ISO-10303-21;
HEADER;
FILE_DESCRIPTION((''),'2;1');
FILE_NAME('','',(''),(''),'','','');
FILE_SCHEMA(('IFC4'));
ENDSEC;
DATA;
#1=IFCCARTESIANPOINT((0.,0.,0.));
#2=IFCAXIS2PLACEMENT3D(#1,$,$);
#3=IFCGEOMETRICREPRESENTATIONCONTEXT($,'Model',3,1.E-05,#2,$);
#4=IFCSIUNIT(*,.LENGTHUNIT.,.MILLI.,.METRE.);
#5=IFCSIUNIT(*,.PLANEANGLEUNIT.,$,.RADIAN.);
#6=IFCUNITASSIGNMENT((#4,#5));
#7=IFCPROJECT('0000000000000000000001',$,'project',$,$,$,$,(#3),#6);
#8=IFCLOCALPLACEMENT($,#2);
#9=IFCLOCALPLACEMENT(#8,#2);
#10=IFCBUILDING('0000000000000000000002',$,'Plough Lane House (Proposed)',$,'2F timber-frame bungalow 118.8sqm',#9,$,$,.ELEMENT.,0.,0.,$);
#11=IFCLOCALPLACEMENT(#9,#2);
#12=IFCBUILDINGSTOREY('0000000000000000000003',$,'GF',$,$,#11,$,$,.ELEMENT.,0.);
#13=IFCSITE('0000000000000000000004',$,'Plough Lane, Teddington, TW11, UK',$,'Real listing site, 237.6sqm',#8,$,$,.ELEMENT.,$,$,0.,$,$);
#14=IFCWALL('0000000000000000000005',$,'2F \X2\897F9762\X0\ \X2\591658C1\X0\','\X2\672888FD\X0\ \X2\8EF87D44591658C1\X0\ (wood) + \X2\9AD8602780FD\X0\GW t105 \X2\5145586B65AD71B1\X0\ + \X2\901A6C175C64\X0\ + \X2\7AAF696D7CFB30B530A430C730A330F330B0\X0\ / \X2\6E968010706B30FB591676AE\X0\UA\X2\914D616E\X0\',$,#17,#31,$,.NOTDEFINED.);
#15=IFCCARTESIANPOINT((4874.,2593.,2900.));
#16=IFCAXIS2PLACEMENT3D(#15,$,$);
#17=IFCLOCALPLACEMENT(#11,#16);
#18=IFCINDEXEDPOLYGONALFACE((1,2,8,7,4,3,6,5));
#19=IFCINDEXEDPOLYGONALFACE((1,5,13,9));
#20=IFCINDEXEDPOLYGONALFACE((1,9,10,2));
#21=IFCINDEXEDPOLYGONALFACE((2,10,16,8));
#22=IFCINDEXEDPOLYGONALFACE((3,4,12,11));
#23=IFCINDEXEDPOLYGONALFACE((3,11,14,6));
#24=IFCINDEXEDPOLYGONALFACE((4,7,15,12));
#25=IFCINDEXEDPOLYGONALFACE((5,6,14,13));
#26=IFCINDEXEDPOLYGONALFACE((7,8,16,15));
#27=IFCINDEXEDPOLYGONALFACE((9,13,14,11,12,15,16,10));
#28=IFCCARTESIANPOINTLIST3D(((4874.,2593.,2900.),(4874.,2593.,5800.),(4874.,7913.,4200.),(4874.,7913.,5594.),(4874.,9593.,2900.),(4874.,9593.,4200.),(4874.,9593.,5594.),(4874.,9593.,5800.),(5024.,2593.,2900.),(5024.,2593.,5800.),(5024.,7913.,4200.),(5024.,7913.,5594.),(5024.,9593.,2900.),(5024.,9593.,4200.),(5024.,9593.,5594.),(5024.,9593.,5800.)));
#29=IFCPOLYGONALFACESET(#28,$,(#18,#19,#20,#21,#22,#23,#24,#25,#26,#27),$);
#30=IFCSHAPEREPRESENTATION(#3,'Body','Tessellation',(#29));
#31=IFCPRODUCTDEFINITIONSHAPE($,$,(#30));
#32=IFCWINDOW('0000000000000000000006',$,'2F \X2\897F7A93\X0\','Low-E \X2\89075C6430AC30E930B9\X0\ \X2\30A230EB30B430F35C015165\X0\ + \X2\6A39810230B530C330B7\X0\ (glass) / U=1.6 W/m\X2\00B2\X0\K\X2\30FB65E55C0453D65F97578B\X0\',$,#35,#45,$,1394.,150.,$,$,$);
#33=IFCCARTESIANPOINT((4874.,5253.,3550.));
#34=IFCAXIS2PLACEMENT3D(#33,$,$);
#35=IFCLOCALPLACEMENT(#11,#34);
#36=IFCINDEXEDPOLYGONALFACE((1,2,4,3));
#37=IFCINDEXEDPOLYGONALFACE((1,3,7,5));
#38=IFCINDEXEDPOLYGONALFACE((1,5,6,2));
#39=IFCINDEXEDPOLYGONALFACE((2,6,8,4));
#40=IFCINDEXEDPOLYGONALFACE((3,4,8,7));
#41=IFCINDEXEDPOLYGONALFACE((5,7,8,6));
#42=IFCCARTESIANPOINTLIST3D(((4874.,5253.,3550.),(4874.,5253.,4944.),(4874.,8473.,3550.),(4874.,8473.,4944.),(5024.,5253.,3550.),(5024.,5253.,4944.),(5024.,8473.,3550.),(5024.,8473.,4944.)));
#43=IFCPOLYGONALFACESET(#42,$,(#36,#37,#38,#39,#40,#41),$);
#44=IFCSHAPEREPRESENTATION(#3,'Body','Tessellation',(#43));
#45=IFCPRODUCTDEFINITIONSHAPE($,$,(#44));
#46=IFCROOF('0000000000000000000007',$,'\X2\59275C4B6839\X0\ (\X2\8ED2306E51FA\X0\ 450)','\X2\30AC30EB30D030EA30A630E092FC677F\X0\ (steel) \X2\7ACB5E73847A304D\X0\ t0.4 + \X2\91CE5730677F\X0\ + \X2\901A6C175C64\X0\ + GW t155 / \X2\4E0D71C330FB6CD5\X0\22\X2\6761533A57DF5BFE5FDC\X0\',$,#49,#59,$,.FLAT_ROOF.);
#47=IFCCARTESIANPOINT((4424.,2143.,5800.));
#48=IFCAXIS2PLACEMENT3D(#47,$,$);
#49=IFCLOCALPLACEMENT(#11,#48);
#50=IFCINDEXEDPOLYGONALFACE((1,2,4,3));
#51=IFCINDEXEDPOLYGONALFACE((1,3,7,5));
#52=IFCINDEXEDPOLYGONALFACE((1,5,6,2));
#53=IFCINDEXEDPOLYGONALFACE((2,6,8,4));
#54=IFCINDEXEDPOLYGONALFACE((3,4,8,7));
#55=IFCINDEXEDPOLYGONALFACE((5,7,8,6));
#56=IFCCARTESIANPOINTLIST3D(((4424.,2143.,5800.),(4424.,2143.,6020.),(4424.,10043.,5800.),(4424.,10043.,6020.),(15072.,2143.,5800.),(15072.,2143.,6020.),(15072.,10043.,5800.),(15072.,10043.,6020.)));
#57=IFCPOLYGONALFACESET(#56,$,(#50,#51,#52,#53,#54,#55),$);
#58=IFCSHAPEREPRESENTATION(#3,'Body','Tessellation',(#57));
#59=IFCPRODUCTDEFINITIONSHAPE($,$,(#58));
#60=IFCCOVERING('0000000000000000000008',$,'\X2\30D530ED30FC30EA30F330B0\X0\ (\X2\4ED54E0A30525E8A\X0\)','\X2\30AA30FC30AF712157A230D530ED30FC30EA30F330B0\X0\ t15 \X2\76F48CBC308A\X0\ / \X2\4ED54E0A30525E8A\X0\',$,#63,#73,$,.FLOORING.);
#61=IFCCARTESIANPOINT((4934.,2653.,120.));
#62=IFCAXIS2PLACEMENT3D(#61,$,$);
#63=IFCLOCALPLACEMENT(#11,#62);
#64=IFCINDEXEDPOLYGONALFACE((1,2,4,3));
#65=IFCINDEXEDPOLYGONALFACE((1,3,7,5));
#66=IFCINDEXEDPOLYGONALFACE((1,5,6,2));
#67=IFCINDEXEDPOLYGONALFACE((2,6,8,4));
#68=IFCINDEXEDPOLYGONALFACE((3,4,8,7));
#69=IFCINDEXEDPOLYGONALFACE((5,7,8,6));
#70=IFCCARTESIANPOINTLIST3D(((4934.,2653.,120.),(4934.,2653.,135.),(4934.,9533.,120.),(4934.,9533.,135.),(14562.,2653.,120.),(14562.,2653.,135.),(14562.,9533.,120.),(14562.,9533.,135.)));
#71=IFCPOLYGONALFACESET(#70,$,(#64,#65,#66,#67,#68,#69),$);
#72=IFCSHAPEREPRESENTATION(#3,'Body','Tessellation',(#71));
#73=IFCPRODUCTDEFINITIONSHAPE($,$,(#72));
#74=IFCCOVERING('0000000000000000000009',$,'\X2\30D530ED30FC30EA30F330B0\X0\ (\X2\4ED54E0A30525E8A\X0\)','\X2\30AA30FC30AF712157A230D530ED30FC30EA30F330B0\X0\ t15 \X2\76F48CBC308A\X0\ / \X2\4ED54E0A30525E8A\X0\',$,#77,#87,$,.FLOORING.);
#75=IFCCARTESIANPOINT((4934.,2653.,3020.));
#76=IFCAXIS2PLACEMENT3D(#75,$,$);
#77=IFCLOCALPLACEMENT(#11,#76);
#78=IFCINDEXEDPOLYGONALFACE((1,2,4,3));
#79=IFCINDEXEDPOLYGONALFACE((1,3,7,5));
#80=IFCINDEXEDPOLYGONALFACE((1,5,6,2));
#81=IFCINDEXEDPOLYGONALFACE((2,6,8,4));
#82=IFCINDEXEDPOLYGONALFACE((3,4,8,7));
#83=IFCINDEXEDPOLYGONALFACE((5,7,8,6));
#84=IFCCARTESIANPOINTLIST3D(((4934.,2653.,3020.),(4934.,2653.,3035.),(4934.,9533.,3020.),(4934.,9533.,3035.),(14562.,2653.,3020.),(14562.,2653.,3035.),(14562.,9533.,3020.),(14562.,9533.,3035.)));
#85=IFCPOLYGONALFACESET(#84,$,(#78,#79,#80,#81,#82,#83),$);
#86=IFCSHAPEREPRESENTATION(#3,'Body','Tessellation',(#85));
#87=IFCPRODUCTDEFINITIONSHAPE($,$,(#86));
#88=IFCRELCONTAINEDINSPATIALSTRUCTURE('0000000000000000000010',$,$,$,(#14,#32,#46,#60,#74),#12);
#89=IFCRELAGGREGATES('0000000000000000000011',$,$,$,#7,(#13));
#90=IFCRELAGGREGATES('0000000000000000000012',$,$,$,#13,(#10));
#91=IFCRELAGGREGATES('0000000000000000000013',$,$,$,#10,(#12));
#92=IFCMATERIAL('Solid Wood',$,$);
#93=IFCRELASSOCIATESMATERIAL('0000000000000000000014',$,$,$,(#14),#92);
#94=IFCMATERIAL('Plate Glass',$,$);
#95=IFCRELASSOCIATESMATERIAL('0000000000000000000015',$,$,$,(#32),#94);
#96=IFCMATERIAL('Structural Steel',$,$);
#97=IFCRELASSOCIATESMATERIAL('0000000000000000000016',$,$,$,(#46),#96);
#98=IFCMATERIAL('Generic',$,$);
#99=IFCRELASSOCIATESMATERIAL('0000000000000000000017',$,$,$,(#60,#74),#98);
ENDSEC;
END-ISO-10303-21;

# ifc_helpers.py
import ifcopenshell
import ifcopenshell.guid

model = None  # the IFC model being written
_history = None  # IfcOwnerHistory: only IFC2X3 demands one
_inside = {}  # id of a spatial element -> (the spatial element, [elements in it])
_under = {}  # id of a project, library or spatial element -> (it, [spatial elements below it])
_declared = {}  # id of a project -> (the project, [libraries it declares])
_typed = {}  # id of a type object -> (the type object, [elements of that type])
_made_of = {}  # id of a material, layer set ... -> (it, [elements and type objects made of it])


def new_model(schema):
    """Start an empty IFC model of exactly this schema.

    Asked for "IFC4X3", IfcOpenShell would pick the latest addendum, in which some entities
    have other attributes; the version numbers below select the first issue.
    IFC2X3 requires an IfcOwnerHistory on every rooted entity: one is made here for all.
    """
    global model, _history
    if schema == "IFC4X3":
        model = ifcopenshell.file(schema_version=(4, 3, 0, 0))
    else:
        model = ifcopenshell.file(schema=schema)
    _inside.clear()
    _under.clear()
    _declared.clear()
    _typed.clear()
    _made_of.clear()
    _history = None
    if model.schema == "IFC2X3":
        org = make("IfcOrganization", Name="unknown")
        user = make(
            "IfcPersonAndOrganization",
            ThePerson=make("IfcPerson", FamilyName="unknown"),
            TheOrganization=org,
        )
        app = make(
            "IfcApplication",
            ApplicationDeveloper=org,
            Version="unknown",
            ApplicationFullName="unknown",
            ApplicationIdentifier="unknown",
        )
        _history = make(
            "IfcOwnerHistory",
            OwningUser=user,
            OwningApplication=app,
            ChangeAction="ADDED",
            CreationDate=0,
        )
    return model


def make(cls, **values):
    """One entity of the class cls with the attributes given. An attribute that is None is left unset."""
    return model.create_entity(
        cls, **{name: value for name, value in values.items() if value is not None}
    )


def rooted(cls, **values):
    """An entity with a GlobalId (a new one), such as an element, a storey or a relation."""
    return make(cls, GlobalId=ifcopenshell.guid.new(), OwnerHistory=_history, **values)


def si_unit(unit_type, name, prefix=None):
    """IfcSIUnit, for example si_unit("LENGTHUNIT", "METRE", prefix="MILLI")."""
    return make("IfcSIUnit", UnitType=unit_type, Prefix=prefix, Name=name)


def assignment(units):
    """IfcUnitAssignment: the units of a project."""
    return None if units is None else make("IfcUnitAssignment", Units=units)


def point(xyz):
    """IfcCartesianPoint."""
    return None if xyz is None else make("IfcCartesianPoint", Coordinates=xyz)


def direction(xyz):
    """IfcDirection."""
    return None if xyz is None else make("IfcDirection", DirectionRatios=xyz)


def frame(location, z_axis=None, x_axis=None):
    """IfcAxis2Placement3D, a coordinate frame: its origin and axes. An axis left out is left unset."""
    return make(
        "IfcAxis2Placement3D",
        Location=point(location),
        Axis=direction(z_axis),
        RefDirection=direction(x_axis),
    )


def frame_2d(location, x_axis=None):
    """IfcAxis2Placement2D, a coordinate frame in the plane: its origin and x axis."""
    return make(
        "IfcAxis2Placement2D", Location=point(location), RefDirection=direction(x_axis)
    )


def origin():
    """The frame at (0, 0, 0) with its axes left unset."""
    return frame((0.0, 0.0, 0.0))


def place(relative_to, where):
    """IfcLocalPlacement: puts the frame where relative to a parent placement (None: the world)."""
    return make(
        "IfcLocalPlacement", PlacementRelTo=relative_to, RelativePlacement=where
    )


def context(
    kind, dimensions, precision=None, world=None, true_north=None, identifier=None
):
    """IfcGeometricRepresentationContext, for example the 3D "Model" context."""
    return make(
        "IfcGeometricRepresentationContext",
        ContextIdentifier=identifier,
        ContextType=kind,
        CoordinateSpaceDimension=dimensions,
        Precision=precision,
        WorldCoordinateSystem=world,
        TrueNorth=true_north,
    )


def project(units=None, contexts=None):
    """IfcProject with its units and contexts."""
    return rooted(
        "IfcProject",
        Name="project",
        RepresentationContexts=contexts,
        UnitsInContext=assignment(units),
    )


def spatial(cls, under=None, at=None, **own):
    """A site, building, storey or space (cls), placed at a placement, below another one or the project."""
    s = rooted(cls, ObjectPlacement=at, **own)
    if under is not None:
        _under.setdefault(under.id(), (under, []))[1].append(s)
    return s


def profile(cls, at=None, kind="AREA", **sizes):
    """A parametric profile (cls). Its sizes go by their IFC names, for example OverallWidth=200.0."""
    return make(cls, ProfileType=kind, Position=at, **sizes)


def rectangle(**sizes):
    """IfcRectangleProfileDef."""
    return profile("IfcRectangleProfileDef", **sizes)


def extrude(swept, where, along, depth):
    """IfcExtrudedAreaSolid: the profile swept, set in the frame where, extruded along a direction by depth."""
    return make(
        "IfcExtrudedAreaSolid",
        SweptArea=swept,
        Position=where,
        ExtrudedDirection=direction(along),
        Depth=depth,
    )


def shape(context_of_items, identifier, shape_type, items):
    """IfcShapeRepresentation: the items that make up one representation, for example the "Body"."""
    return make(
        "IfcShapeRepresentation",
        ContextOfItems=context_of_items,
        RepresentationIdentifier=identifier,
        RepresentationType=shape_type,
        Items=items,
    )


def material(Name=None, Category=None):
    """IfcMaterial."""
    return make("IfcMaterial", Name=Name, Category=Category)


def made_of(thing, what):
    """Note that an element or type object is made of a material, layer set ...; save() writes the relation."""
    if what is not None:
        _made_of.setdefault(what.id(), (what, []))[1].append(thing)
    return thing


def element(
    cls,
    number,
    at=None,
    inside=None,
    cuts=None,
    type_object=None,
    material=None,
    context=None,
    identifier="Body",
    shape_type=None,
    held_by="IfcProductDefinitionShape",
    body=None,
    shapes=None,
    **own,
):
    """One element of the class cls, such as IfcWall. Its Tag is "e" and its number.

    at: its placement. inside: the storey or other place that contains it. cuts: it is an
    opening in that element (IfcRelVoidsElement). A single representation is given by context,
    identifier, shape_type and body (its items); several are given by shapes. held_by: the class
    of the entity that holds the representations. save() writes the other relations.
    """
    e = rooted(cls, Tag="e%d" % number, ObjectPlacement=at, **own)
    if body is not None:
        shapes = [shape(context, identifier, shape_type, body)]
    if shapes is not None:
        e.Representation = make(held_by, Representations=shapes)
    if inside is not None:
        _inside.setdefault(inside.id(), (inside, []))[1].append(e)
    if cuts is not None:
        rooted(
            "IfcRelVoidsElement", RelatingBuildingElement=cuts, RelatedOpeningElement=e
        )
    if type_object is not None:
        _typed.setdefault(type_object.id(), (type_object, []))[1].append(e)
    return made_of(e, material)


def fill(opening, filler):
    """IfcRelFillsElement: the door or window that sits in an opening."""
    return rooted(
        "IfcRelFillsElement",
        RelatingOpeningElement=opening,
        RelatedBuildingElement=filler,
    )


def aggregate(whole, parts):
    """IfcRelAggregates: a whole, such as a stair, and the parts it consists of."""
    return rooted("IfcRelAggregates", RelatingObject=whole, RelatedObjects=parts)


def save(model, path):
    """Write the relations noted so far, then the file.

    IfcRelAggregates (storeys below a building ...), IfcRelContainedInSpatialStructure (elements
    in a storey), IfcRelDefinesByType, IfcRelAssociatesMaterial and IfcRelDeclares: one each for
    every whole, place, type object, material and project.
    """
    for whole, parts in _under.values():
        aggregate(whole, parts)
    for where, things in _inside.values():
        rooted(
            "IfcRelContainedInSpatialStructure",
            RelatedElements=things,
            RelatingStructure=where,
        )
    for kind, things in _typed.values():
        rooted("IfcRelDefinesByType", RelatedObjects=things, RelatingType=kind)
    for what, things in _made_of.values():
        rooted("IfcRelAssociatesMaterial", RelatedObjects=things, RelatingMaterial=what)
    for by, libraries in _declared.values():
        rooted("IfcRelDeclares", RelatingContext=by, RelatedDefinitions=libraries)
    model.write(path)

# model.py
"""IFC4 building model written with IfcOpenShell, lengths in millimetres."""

from ifc_helpers import new_model, si_unit, frame, frame_2d, origin, place, context, project, spatial, rectangle, extrude, material, element, fill, save


model = new_model("IFC4")

# Units and contexts
model_context = context("Model", 3, precision=1e-05, world=origin())
ifc_project = project(units=[si_unit("LENGTHUNIT", "METRE", prefix="MILLI"), si_unit("PLANEANGLEUNIT", "RADIAN")], contexts=[model_context])

# Site, building, storey
site_placement = place(None, origin())
site = spatial("IfcSite", under=ifc_project, at=site_placement, Name="Plough Lane, Teddington, TW11, UK", ObjectType="Real listing site, 237.6sqm", CompositionType="ELEMENT", RefElevation=0.0)
building_placement = place(site_placement, origin())
building = spatial("IfcBuilding", under=site, at=building_placement, Name="Plough Lane House (Proposed)", ObjectType="2F timber-frame bungalow 118.8sqm", CompositionType="ELEMENT", ElevationOfRefHeight=0.0, ElevationOfTerrain=0.0)
storey_placement = place(building_placement, origin())
storey = spatial("IfcBuildingStorey", under=building, at=storey_placement, Name="GF", CompositionType="ELEMENT", Elevation=0.0)

# Shared definitions
ifc_material_1 = material(Name="Solid Wood")

# Shared definitions
ifc_material_2 = material(Name="Plate Glass")

# Wall, opening, window
wall_1_placement = place(storey_placement, frame((4874.0, 2593.0, 2900.0)))
wall_1 = element("IfcWall", 1, at=wall_1_placement, inside=storey, material=ifc_material_1, Name="2F 西面 外壁", Description="木製 軸組外壁 (wood) + 高性能GW t105 充填断熱 + 通気層 + 窯業系サイディング / 準耐火・外皮UA配慮", PredefinedType="NOTDEFINED", context=model_context, shape_type="SweptSolid", body=[
    extrude(rectangle(XDim=150.0, YDim=7000.0, at=frame_2d((75.0, 3500.0))), frame((4874.0, 2593.0, 2900.0)), (0.0, 0.0, 1.0), 2900.0),
])
opening_1_placement = place(storey_placement, frame((4874.0, 5253.0, 3550.0)))
opening_1 = element("IfcOpeningElement", 2, at=opening_1_placement, cuts=wall_1, PredefinedType="NOTDEFINED", context=model_context, shape_type="SweptSolid", body=[
    extrude(rectangle(XDim=150.0, YDim=3220.0, at=frame_2d((75.0, 1610.0))), frame((4874.0, 5253.0, 3550.0)), (0.0, 0.0, 1.0), 1394.0),
])
window_1_placement = place(storey_placement, frame((4874.0, 5253.0, 3550.0)))
window_1 = element("IfcWindow", 3, at=window_1_placement, inside=storey, material=ifc_material_2, Name="2F 西窓", Description="Low-E 複層ガラス アルゴン封入 + 樹脂サッシ (glass) / U=1.6 W/m²K・日射取得型", OverallHeight=1394.0, OverallWidth=150.0, context=model_context, shape_type="SweptSolid", body=[
    extrude(rectangle(XDim=150.0, YDim=3220.0, at=frame_2d((75.0, 1610.0))), frame((4874.0, 5253.0, 3550.0)), (0.0, 0.0, 1.0), 1394.0),
])
fill(opening_1, window_1)

# Roof
ifc_material_3 = material(Name="Structural Steel")
roof_placement = place(storey_placement, frame((4424.0, 2143.0, 5800.0)))
element("IfcRoof", 4, at=roof_placement, inside=storey, material=ifc_material_3, Name="大屋根 (軒の出 450)", Description="ガルバリウム鋼板 (steel) 立平葺き t0.4 + 野地板 + 通気層 + GW t155 / 不燃・法22条区域対応", PredefinedType="FLAT_ROOF", context=model_context, shape_type="SweptSolid", body=[
    extrude(rectangle(XDim=10648.0, YDim=7900.0, at=frame_2d((5324.0, 3950.0))), frame((4424.0, 2143.0, 5800.0)), (0.0, 0.0, 1.0), 220.0),
])

# Coverings
ifc_material_4 = material(Name="Generic")
covering_1_placement = place(storey_placement, frame((4934.0, 2653.0, 120.0)))
element("IfcCovering", 5, at=covering_1_placement, inside=storey, material=ifc_material_4, Name="フローリング (仕上げ床)", Description="オーク無垢フローリング t15 直貼り / 仕上げ床", PredefinedType="FLOORING", context=model_context, shape_type="SweptSolid", body=[
    extrude(rectangle(XDim=9628.0, YDim=6880.0, at=frame_2d((4814.0, 3440.0))), frame((4934.0, 2653.0, 120.0)), (0.0, 0.0, 1.0), 15.0),
])
covering_2_placement = place(storey_placement, frame((4934.0, 2653.0, 3020.0)))
element("IfcCovering", 6, at=covering_2_placement, inside=storey, material=ifc_material_4, Name="フローリング (仕上げ床)", Description="オーク無垢フローリング t15 直貼り / 仕上げ床", PredefinedType="FLOORING", context=model_context, shape_type="SweptSolid", body=[
    extrude(rectangle(XDim=9628.0, YDim=6880.0, at=frame_2d((4814.0, 3440.0))), frame((4934.0, 2653.0, 3020.0)), (0.0, 0.0, 1.0), 15.0),
])

save(model, "model.ifc")
